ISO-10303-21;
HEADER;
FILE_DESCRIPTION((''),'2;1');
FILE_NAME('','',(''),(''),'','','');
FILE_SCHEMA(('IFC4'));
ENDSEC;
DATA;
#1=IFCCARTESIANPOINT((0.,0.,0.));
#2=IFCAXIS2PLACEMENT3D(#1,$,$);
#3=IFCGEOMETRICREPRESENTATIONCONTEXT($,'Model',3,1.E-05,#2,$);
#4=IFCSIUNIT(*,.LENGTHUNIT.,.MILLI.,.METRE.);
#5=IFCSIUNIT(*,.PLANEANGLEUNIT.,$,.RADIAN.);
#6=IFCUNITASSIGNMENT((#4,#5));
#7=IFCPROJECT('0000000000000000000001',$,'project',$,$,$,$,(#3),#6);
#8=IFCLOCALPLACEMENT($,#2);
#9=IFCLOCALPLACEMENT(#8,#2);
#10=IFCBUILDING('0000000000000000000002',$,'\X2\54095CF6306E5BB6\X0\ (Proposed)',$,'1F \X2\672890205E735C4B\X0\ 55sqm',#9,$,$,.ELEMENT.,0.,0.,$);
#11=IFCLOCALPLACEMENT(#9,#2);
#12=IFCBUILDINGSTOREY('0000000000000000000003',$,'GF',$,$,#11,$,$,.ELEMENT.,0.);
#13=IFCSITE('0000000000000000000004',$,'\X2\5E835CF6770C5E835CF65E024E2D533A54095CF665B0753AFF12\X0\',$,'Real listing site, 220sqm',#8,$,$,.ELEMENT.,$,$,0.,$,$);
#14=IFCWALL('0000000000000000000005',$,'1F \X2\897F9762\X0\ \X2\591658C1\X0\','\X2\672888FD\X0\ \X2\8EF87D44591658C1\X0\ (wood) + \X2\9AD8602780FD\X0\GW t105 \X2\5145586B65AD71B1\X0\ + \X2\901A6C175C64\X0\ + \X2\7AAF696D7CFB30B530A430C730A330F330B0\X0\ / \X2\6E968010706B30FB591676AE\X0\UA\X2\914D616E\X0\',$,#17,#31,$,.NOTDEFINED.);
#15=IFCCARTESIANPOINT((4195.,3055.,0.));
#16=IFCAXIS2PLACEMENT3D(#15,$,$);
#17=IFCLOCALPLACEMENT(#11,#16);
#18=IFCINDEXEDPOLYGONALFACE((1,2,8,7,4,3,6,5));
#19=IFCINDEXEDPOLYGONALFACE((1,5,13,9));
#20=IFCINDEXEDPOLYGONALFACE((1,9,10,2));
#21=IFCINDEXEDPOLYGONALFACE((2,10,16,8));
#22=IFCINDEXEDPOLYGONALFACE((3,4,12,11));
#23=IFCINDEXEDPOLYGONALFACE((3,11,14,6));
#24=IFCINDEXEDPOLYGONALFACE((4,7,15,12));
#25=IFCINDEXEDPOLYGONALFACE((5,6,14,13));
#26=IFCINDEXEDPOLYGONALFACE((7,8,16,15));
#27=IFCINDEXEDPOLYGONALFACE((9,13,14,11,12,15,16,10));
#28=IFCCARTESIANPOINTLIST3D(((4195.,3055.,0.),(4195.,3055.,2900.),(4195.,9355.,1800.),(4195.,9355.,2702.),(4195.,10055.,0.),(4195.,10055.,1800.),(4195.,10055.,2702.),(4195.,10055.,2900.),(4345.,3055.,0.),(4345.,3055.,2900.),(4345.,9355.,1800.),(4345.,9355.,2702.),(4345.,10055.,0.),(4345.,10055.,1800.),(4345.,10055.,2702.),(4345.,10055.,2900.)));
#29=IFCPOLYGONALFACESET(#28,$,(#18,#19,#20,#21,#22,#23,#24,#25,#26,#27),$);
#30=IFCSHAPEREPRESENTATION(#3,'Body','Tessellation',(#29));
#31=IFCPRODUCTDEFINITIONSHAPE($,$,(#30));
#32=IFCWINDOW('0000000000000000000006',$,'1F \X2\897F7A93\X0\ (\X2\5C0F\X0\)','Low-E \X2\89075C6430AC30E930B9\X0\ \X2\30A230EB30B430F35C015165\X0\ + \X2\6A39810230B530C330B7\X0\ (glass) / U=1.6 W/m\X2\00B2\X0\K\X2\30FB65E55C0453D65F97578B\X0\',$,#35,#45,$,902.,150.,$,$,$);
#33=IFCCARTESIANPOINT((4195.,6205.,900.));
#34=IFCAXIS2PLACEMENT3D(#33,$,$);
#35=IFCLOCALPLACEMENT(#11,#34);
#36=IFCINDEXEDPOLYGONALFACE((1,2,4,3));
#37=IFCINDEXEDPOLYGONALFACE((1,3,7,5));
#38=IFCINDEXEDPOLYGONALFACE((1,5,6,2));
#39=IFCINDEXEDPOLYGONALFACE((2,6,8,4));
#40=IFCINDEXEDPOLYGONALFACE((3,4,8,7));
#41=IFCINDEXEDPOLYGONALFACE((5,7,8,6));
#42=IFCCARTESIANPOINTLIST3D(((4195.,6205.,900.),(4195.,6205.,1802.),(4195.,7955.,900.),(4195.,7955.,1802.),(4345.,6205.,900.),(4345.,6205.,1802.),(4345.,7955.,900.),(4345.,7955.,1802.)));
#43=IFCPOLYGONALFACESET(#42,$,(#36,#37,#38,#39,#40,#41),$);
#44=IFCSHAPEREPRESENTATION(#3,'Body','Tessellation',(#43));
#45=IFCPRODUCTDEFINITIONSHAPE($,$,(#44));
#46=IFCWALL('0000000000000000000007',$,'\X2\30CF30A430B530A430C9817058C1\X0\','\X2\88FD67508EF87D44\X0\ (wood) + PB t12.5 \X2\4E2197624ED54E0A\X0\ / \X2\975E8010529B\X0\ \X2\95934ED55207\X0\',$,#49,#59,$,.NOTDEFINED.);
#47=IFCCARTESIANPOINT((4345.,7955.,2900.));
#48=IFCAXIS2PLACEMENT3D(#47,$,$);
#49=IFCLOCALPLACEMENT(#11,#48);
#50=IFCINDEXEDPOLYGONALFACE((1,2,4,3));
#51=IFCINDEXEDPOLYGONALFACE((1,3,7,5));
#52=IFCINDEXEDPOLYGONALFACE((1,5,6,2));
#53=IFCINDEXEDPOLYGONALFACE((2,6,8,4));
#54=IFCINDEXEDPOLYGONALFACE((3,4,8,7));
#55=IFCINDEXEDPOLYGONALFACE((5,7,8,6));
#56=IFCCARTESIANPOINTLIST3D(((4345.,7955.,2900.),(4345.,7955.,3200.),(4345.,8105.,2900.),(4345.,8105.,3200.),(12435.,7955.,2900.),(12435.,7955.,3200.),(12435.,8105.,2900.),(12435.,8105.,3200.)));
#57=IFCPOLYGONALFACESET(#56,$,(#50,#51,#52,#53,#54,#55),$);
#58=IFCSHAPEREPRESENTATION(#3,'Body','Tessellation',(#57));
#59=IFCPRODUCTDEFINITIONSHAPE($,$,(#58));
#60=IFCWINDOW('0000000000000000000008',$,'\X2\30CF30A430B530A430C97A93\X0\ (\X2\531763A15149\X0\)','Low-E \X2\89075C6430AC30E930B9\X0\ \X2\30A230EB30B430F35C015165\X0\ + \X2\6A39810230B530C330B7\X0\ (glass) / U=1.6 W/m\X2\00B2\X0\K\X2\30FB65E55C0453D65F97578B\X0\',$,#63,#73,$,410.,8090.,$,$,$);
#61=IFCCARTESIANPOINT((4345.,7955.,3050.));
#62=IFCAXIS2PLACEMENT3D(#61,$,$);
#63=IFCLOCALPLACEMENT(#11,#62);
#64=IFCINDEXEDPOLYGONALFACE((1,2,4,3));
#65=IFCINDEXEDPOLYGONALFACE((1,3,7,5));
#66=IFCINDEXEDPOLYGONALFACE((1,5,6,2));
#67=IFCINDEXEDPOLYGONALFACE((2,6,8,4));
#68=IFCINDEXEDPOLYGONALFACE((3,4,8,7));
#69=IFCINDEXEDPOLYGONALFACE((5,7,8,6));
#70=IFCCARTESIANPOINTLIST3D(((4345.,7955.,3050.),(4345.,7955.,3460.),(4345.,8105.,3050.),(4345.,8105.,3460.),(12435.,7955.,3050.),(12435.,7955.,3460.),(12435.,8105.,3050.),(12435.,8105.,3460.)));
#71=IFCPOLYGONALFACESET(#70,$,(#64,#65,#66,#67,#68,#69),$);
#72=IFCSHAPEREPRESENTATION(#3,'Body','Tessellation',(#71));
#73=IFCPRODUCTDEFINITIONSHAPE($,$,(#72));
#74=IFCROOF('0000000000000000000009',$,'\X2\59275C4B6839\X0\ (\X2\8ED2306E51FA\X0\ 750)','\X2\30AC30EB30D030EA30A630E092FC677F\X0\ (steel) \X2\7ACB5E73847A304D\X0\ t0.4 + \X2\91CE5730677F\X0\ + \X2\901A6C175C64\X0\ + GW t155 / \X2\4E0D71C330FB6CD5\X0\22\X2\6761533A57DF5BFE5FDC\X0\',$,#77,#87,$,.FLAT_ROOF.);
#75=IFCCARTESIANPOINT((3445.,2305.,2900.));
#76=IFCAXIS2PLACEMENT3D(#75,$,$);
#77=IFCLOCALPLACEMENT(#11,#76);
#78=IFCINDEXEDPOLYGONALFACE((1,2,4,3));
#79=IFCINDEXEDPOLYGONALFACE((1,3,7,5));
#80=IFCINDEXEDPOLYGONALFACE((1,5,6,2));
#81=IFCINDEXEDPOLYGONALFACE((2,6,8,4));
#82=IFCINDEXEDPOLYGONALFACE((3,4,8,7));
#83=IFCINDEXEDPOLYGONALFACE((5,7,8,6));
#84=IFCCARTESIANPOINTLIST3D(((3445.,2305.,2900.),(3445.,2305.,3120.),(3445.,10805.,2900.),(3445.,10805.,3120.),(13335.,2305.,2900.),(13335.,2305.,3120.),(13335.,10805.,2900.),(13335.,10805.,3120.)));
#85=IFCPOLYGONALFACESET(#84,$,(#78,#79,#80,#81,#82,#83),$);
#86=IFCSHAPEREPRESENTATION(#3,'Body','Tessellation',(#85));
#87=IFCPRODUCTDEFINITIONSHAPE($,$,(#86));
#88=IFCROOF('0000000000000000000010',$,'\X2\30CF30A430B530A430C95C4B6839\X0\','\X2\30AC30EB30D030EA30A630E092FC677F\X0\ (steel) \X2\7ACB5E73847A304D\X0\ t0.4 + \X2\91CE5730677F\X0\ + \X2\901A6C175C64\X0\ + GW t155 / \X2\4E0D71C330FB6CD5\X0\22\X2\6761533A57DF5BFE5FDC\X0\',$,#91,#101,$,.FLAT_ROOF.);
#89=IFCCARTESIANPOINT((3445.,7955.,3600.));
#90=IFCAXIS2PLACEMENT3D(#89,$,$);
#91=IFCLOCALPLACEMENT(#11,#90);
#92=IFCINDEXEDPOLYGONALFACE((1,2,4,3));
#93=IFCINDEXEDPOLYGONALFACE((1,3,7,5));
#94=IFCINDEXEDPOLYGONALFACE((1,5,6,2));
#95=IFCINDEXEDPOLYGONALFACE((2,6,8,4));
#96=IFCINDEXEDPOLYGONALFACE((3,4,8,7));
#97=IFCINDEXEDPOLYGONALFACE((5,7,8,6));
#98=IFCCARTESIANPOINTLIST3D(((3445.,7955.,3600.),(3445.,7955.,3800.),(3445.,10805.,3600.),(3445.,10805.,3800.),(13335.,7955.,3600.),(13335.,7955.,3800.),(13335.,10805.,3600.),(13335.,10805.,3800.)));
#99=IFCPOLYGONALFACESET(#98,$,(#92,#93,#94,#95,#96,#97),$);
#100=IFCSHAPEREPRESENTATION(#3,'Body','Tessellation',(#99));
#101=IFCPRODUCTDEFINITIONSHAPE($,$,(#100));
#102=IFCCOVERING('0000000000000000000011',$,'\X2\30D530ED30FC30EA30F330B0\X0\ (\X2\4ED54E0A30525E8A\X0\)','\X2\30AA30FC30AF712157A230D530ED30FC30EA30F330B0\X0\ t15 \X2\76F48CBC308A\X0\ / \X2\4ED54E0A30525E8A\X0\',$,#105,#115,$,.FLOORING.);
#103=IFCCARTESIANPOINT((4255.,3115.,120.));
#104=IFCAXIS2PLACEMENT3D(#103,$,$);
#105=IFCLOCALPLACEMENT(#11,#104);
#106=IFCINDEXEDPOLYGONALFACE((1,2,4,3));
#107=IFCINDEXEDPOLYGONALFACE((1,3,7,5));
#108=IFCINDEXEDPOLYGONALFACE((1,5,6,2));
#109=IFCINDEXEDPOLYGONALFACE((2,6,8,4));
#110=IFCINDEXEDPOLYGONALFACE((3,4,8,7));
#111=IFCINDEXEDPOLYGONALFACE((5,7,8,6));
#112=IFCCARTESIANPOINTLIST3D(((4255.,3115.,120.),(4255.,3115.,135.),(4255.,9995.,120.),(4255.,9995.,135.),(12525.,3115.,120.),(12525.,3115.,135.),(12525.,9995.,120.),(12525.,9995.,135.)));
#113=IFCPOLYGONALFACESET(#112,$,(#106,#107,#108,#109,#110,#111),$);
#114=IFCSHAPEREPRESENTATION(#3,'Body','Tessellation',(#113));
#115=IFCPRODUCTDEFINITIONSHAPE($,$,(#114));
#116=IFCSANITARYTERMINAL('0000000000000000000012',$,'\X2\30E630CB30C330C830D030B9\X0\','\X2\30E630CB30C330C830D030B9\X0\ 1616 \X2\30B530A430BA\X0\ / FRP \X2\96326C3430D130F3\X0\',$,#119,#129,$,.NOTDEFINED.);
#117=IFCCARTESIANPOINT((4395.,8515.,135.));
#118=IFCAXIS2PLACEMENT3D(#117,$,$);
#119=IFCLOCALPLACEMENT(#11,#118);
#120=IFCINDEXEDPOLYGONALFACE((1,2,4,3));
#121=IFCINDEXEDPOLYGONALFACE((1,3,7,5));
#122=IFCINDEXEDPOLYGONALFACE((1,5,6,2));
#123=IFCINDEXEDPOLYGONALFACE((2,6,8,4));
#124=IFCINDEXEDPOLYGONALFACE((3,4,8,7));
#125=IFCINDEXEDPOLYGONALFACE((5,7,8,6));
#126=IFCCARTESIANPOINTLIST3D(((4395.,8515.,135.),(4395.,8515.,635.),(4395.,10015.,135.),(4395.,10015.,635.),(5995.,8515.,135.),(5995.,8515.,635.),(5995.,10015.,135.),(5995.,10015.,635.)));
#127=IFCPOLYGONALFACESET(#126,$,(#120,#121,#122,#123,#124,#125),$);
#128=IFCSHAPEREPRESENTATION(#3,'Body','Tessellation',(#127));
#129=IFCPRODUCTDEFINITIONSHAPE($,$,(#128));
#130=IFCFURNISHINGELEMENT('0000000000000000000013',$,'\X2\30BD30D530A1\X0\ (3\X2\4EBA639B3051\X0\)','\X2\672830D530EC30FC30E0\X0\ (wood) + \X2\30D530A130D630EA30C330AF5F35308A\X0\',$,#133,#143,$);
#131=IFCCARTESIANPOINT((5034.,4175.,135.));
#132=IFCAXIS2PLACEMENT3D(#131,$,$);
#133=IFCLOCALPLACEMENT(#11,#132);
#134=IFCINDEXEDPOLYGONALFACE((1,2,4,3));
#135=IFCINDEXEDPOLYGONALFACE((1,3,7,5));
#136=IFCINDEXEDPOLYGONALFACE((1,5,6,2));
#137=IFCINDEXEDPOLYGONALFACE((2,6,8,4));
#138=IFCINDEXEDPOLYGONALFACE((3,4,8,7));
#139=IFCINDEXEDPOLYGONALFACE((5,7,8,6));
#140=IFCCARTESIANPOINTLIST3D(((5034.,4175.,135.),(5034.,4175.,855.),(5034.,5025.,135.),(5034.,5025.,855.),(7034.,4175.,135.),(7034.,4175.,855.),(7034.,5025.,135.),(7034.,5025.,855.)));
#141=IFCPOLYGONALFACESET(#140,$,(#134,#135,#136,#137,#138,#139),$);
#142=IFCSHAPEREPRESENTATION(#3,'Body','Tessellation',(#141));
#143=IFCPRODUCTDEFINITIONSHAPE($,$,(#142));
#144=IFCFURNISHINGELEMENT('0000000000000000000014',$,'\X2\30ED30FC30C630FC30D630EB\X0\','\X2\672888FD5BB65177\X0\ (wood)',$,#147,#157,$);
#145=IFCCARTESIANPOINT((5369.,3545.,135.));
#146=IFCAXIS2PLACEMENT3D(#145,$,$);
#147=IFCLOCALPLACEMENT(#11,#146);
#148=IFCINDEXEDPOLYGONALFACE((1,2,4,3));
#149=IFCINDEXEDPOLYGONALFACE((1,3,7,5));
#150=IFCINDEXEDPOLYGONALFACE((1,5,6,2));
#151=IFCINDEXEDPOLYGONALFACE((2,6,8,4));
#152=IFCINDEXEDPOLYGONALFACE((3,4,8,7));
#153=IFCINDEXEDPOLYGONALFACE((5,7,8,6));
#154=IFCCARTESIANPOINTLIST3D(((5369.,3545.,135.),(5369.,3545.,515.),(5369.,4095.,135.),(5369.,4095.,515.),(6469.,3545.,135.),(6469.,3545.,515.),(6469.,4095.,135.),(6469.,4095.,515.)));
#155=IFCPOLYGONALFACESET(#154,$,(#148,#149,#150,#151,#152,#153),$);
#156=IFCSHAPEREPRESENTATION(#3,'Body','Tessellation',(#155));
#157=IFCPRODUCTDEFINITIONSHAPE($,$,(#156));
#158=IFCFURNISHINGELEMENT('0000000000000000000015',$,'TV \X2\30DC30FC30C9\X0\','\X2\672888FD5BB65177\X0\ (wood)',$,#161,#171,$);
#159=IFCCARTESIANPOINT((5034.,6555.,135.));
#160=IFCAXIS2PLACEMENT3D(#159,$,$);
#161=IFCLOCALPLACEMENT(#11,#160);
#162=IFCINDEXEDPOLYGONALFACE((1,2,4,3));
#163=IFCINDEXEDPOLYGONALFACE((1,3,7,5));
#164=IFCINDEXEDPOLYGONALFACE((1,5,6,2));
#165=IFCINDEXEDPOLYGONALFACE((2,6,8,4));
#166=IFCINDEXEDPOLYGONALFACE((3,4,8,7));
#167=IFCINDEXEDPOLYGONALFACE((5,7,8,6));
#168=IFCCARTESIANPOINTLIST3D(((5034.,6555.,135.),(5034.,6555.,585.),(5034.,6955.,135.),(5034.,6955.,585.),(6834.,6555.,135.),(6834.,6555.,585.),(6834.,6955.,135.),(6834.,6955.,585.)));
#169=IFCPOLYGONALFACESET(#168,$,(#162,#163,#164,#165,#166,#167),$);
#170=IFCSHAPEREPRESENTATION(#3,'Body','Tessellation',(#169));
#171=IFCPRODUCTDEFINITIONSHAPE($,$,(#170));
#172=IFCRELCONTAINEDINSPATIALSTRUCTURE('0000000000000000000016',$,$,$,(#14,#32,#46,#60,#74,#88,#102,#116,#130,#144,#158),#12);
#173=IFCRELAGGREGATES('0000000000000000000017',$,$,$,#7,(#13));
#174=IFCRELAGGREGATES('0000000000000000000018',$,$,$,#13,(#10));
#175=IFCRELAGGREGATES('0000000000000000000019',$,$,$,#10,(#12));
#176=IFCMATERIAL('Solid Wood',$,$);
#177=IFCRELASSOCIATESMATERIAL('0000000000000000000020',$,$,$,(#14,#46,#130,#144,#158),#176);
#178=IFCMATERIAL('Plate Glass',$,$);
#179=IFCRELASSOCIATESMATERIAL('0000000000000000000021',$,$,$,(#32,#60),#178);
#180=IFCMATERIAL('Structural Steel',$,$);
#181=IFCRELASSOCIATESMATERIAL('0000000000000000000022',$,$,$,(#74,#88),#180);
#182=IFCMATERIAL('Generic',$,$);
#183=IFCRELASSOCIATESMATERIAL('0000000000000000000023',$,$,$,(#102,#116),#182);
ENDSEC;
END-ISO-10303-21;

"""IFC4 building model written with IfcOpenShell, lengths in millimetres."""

from ifc_helpers import new_model, si_unit, frame, frame_2d, origin, place, context, project, spatial, rectangle, extrude, material, element, fill, save


model = new_model("IFC4")

# Units and contexts
model_context = context("Model", 3, precision=1e-05, world=origin())
ifc_project = project(units=[si_unit("LENGTHUNIT", "METRE", prefix="MILLI"), si_unit("PLANEANGLEUNIT", "RADIAN")], contexts=[model_context])

# Site, building, storey
site_placement = place(None, origin())
site = spatial("IfcSite", under=ifc_project, at=site_placement, Name="広島県広島市中区吉島新町２", ObjectType="Real listing site, 220sqm", CompositionType="ELEMENT", RefElevation=0.0)
building_placement = place(site_placement, origin())
building = spatial("IfcBuilding", under=site, at=building_placement, Name="吉島の家 (Proposed)", ObjectType="1F 木造平屋 55sqm", CompositionType="ELEMENT", ElevationOfRefHeight=0.0, ElevationOfTerrain=0.0)
storey_placement = place(building_placement, origin())
storey = spatial("IfcBuildingStorey", under=building, at=storey_placement, Name="GF", CompositionType="ELEMENT", Elevation=0.0)

# Shared definitions
ifc_material_1 = material(Name="Solid Wood")

# Shared definitions
ifc_material_2 = material(Name="Plate Glass")

# Wall, opening, window
wall_1_placement = place(storey_placement, frame((4195.0, 3055.0, 0.0)))
wall_1 = element("IfcWall", 1, at=wall_1_placement, inside=storey, material=ifc_material_1, Name="1F 西面 外壁", Description="木製 軸組外壁 (wood) + 高性能GW t105 充填断熱 + 通気層 + 窯業系サイディング / 準耐火・外皮UA配慮", PredefinedType="NOTDEFINED", context=model_context, shape_type="SweptSolid", body=[
    extrude(rectangle(XDim=150.0, YDim=7000.0, at=frame_2d((75.0, 3500.0))), frame((4195.0, 3055.0, 0.0)), (0.0, 0.0, 1.0), 2900.0),
])
opening_1_placement = place(storey_placement, frame((4195.0, 6205.0, 900.0)))
opening_1 = element("IfcOpeningElement", 2, at=opening_1_placement, cuts=wall_1, PredefinedType="NOTDEFINED", context=model_context, shape_type="SweptSolid", body=[
    extrude(rectangle(XDim=150.0, YDim=1750.0, at=frame_2d((75.0, 875.0))), frame((4195.0, 6205.0, 900.0)), (0.0, 0.0, 1.0), 902.0),
])
window_1_placement = place(storey_placement, frame((4195.0, 6205.0, 900.0)))
window_1 = element("IfcWindow", 3, at=window_1_placement, inside=storey, material=ifc_material_2, Name="1F 西窓 (小)", Description="Low-E 複層ガラス アルゴン封入 + 樹脂サッシ (glass) / U=1.6 W/m²K・日射取得型", OverallHeight=902.0, OverallWidth=150.0, context=model_context, shape_type="SweptSolid", body=[
    extrude(rectangle(XDim=150.0, YDim=1750.0, at=frame_2d((75.0, 875.0))), frame((4195.0, 6205.0, 900.0)), (0.0, 0.0, 1.0), 902.0),
])
fill(opening_1, window_1)

# Wall, opening, window
wall_2_placement = place(storey_placement, frame((4345.0, 7955.0, 2900.0)))
wall_2 = element("IfcWall", 4, at=wall_2_placement, inside=storey, material=ifc_material_1, Name="ハイサイド腰壁", Description="製材軸組 (wood) + PB t12.5 両面仕上 / 非耐力 間仕切", PredefinedType="NOTDEFINED", context=model_context, shape_type="SweptSolid", body=[
    extrude(rectangle(XDim=8090.0, YDim=150.0, at=frame_2d((4045.0, 75.0))), frame((4345.0, 7955.0, 2900.0)), (0.0, 0.0, 1.0), 700.0),
])
opening_2_placement = place(storey_placement, frame((4345.0, 7955.0, 3050.0)))
opening_2 = element("IfcOpeningElement", 5, at=opening_2_placement, cuts=wall_2, PredefinedType="NOTDEFINED", context=model_context, shape_type="SweptSolid", body=[
    extrude(rectangle(XDim=8090.0, YDim=150.0, at=frame_2d((4045.0, 75.0))), frame((4345.0, 7955.0, 3050.0)), (0.0, 0.0, 1.0), 410.0),
])
window_2_placement = place(storey_placement, frame((4345.0, 7955.0, 3050.0)))
window_2 = element("IfcWindow", 6, at=window_2_placement, inside=storey, material=ifc_material_2, Name="ハイサイド窓 (北採光)", Description="Low-E 複層ガラス アルゴン封入 + 樹脂サッシ (glass) / U=1.6 W/m²K・日射取得型", OverallHeight=410.0, OverallWidth=8090.0, context=model_context, shape_type="SweptSolid", body=[
    extrude(rectangle(XDim=8090.0, YDim=150.0, at=frame_2d((4045.0, 75.0))), frame((4345.0, 7955.0, 3050.0)), (0.0, 0.0, 1.0), 410.0),
])
fill(opening_2, window_2)

# Roofs
ifc_material_3 = material(Name="Structural Steel")
roof_1_placement = place(storey_placement, frame((3445.0, 2305.0, 2900.0)))
element("IfcRoof", 7, at=roof_1_placement, inside=storey, material=ifc_material_3, Name="大屋根 (軒の出 750)", Description="ガルバリウム鋼板 (steel) 立平葺き t0.4 + 野地板 + 通気層 + GW t155 / 不燃・法22条区域対応", PredefinedType="FLAT_ROOF", context=model_context, shape_type="SweptSolid", body=[
    extrude(rectangle(XDim=9890.0, YDim=8500.0, at=frame_2d((4945.0, 4250.0))), frame((3445.0, 2305.0, 2900.0)), (0.0, 0.0, 1.0), 220.0),
])
roof_2_placement = place(storey_placement, frame((3445.0, 7955.0, 3600.0)))
element("IfcRoof", 8, at=roof_2_placement, inside=storey, material=ifc_material_3, Name="ハイサイド屋根", Description="ガルバリウム鋼板 (steel) 立平葺き t0.4 + 野地板 + 通気層 + GW t155 / 不燃・法22条区域対応", PredefinedType="FLAT_ROOF", context=model_context, shape_type="SweptSolid", body=[
    extrude(rectangle(XDim=9890.0, YDim=2850.0, at=frame_2d((4945.0, 1425.0))), frame((3445.0, 7955.0, 3600.0)), (0.0, 0.0, 1.0), 200.0),
])

# Covering
ifc_material_4 = material(Name="Generic")
covering_placement = place(storey_placement, frame((4255.0, 3115.0, 120.0)))
element("IfcCovering", 9, at=covering_placement, inside=storey, material=ifc_material_4, Name="フローリング (仕上げ床)", Description="オーク無垢フローリング t15 直貼り / 仕上げ床", PredefinedType="FLOORING", context=model_context, shape_type="SweptSolid", body=[
    extrude(rectangle(XDim=8270.0, YDim=6880.0, at=frame_2d((4135.0, 3440.0))), frame((4255.0, 3115.0, 120.0)), (0.0, 0.0, 1.0), 15.0),
])

# Sanitary terminal
sanitary_terminal_placement = place(storey_placement, frame((4395.0, 8515.0, 135.0)))
element("IfcSanitaryTerminal", 10, at=sanitary_terminal_placement, inside=storey, material=ifc_material_4, Name="ユニットバス", Description="ユニットバス 1616 サイズ / FRP 防水パン", PredefinedType="NOTDEFINED", context=model_context, shape_type="SweptSolid", body=[
    extrude(rectangle(XDim=1600.0, YDim=1500.0, at=frame_2d((800.0, 750.0))), frame((4395.0, 8515.0, 135.0)), (0.0, 0.0, 1.0), 500.0),
])

# Furnishing elements
furnishing_1_placement = place(storey_placement, frame((5034.0, 4175.0, 135.0)))
element("IfcFurnishingElement", 11, at=furnishing_1_placement, inside=storey, material=ifc_material_1, Name="ソファ (3人掛け)", Description="木フレーム (wood) + ファブリック張り", context=model_context, shape_type="SweptSolid", body=[
    extrude(rectangle(XDim=2000.0, YDim=850.0, at=frame_2d((1000.0, 425.0))), frame((5034.0, 4175.0, 135.0)), (0.0, 0.0, 1.0), 720.0),
])
furnishing_2_placement = place(storey_placement, frame((5369.0, 3545.0, 135.0)))
element("IfcFurnishingElement", 12, at=furnishing_2_placement, inside=storey, material=ifc_material_1, Name="ローテーブル", Description="木製家具 (wood)", context=model_context, shape_type="SweptSolid", body=[
    extrude(rectangle(XDim=1100.0, YDim=550.0, at=frame_2d((550.0, 275.0))), frame((5369.0, 3545.0, 135.0)), (0.0, 0.0, 1.0), 380.0),
])
furnishing_3_placement = place(storey_placement, frame((5034.0, 6555.0, 135.0)))
element("IfcFurnishingElement", 13, at=furnishing_3_placement, inside=storey, material=ifc_material_1, Name="TV ボード", Description="木製家具 (wood)", context=model_context, shape_type="SweptSolid", body=[
    extrude(rectangle(XDim=1800.0, YDim=400.0, at=frame_2d((900.0, 200.0))), frame((5034.0, 6555.0, 135.0)), (0.0, 0.0, 1.0), 450.0),
])

save(model, "model.ifc")
